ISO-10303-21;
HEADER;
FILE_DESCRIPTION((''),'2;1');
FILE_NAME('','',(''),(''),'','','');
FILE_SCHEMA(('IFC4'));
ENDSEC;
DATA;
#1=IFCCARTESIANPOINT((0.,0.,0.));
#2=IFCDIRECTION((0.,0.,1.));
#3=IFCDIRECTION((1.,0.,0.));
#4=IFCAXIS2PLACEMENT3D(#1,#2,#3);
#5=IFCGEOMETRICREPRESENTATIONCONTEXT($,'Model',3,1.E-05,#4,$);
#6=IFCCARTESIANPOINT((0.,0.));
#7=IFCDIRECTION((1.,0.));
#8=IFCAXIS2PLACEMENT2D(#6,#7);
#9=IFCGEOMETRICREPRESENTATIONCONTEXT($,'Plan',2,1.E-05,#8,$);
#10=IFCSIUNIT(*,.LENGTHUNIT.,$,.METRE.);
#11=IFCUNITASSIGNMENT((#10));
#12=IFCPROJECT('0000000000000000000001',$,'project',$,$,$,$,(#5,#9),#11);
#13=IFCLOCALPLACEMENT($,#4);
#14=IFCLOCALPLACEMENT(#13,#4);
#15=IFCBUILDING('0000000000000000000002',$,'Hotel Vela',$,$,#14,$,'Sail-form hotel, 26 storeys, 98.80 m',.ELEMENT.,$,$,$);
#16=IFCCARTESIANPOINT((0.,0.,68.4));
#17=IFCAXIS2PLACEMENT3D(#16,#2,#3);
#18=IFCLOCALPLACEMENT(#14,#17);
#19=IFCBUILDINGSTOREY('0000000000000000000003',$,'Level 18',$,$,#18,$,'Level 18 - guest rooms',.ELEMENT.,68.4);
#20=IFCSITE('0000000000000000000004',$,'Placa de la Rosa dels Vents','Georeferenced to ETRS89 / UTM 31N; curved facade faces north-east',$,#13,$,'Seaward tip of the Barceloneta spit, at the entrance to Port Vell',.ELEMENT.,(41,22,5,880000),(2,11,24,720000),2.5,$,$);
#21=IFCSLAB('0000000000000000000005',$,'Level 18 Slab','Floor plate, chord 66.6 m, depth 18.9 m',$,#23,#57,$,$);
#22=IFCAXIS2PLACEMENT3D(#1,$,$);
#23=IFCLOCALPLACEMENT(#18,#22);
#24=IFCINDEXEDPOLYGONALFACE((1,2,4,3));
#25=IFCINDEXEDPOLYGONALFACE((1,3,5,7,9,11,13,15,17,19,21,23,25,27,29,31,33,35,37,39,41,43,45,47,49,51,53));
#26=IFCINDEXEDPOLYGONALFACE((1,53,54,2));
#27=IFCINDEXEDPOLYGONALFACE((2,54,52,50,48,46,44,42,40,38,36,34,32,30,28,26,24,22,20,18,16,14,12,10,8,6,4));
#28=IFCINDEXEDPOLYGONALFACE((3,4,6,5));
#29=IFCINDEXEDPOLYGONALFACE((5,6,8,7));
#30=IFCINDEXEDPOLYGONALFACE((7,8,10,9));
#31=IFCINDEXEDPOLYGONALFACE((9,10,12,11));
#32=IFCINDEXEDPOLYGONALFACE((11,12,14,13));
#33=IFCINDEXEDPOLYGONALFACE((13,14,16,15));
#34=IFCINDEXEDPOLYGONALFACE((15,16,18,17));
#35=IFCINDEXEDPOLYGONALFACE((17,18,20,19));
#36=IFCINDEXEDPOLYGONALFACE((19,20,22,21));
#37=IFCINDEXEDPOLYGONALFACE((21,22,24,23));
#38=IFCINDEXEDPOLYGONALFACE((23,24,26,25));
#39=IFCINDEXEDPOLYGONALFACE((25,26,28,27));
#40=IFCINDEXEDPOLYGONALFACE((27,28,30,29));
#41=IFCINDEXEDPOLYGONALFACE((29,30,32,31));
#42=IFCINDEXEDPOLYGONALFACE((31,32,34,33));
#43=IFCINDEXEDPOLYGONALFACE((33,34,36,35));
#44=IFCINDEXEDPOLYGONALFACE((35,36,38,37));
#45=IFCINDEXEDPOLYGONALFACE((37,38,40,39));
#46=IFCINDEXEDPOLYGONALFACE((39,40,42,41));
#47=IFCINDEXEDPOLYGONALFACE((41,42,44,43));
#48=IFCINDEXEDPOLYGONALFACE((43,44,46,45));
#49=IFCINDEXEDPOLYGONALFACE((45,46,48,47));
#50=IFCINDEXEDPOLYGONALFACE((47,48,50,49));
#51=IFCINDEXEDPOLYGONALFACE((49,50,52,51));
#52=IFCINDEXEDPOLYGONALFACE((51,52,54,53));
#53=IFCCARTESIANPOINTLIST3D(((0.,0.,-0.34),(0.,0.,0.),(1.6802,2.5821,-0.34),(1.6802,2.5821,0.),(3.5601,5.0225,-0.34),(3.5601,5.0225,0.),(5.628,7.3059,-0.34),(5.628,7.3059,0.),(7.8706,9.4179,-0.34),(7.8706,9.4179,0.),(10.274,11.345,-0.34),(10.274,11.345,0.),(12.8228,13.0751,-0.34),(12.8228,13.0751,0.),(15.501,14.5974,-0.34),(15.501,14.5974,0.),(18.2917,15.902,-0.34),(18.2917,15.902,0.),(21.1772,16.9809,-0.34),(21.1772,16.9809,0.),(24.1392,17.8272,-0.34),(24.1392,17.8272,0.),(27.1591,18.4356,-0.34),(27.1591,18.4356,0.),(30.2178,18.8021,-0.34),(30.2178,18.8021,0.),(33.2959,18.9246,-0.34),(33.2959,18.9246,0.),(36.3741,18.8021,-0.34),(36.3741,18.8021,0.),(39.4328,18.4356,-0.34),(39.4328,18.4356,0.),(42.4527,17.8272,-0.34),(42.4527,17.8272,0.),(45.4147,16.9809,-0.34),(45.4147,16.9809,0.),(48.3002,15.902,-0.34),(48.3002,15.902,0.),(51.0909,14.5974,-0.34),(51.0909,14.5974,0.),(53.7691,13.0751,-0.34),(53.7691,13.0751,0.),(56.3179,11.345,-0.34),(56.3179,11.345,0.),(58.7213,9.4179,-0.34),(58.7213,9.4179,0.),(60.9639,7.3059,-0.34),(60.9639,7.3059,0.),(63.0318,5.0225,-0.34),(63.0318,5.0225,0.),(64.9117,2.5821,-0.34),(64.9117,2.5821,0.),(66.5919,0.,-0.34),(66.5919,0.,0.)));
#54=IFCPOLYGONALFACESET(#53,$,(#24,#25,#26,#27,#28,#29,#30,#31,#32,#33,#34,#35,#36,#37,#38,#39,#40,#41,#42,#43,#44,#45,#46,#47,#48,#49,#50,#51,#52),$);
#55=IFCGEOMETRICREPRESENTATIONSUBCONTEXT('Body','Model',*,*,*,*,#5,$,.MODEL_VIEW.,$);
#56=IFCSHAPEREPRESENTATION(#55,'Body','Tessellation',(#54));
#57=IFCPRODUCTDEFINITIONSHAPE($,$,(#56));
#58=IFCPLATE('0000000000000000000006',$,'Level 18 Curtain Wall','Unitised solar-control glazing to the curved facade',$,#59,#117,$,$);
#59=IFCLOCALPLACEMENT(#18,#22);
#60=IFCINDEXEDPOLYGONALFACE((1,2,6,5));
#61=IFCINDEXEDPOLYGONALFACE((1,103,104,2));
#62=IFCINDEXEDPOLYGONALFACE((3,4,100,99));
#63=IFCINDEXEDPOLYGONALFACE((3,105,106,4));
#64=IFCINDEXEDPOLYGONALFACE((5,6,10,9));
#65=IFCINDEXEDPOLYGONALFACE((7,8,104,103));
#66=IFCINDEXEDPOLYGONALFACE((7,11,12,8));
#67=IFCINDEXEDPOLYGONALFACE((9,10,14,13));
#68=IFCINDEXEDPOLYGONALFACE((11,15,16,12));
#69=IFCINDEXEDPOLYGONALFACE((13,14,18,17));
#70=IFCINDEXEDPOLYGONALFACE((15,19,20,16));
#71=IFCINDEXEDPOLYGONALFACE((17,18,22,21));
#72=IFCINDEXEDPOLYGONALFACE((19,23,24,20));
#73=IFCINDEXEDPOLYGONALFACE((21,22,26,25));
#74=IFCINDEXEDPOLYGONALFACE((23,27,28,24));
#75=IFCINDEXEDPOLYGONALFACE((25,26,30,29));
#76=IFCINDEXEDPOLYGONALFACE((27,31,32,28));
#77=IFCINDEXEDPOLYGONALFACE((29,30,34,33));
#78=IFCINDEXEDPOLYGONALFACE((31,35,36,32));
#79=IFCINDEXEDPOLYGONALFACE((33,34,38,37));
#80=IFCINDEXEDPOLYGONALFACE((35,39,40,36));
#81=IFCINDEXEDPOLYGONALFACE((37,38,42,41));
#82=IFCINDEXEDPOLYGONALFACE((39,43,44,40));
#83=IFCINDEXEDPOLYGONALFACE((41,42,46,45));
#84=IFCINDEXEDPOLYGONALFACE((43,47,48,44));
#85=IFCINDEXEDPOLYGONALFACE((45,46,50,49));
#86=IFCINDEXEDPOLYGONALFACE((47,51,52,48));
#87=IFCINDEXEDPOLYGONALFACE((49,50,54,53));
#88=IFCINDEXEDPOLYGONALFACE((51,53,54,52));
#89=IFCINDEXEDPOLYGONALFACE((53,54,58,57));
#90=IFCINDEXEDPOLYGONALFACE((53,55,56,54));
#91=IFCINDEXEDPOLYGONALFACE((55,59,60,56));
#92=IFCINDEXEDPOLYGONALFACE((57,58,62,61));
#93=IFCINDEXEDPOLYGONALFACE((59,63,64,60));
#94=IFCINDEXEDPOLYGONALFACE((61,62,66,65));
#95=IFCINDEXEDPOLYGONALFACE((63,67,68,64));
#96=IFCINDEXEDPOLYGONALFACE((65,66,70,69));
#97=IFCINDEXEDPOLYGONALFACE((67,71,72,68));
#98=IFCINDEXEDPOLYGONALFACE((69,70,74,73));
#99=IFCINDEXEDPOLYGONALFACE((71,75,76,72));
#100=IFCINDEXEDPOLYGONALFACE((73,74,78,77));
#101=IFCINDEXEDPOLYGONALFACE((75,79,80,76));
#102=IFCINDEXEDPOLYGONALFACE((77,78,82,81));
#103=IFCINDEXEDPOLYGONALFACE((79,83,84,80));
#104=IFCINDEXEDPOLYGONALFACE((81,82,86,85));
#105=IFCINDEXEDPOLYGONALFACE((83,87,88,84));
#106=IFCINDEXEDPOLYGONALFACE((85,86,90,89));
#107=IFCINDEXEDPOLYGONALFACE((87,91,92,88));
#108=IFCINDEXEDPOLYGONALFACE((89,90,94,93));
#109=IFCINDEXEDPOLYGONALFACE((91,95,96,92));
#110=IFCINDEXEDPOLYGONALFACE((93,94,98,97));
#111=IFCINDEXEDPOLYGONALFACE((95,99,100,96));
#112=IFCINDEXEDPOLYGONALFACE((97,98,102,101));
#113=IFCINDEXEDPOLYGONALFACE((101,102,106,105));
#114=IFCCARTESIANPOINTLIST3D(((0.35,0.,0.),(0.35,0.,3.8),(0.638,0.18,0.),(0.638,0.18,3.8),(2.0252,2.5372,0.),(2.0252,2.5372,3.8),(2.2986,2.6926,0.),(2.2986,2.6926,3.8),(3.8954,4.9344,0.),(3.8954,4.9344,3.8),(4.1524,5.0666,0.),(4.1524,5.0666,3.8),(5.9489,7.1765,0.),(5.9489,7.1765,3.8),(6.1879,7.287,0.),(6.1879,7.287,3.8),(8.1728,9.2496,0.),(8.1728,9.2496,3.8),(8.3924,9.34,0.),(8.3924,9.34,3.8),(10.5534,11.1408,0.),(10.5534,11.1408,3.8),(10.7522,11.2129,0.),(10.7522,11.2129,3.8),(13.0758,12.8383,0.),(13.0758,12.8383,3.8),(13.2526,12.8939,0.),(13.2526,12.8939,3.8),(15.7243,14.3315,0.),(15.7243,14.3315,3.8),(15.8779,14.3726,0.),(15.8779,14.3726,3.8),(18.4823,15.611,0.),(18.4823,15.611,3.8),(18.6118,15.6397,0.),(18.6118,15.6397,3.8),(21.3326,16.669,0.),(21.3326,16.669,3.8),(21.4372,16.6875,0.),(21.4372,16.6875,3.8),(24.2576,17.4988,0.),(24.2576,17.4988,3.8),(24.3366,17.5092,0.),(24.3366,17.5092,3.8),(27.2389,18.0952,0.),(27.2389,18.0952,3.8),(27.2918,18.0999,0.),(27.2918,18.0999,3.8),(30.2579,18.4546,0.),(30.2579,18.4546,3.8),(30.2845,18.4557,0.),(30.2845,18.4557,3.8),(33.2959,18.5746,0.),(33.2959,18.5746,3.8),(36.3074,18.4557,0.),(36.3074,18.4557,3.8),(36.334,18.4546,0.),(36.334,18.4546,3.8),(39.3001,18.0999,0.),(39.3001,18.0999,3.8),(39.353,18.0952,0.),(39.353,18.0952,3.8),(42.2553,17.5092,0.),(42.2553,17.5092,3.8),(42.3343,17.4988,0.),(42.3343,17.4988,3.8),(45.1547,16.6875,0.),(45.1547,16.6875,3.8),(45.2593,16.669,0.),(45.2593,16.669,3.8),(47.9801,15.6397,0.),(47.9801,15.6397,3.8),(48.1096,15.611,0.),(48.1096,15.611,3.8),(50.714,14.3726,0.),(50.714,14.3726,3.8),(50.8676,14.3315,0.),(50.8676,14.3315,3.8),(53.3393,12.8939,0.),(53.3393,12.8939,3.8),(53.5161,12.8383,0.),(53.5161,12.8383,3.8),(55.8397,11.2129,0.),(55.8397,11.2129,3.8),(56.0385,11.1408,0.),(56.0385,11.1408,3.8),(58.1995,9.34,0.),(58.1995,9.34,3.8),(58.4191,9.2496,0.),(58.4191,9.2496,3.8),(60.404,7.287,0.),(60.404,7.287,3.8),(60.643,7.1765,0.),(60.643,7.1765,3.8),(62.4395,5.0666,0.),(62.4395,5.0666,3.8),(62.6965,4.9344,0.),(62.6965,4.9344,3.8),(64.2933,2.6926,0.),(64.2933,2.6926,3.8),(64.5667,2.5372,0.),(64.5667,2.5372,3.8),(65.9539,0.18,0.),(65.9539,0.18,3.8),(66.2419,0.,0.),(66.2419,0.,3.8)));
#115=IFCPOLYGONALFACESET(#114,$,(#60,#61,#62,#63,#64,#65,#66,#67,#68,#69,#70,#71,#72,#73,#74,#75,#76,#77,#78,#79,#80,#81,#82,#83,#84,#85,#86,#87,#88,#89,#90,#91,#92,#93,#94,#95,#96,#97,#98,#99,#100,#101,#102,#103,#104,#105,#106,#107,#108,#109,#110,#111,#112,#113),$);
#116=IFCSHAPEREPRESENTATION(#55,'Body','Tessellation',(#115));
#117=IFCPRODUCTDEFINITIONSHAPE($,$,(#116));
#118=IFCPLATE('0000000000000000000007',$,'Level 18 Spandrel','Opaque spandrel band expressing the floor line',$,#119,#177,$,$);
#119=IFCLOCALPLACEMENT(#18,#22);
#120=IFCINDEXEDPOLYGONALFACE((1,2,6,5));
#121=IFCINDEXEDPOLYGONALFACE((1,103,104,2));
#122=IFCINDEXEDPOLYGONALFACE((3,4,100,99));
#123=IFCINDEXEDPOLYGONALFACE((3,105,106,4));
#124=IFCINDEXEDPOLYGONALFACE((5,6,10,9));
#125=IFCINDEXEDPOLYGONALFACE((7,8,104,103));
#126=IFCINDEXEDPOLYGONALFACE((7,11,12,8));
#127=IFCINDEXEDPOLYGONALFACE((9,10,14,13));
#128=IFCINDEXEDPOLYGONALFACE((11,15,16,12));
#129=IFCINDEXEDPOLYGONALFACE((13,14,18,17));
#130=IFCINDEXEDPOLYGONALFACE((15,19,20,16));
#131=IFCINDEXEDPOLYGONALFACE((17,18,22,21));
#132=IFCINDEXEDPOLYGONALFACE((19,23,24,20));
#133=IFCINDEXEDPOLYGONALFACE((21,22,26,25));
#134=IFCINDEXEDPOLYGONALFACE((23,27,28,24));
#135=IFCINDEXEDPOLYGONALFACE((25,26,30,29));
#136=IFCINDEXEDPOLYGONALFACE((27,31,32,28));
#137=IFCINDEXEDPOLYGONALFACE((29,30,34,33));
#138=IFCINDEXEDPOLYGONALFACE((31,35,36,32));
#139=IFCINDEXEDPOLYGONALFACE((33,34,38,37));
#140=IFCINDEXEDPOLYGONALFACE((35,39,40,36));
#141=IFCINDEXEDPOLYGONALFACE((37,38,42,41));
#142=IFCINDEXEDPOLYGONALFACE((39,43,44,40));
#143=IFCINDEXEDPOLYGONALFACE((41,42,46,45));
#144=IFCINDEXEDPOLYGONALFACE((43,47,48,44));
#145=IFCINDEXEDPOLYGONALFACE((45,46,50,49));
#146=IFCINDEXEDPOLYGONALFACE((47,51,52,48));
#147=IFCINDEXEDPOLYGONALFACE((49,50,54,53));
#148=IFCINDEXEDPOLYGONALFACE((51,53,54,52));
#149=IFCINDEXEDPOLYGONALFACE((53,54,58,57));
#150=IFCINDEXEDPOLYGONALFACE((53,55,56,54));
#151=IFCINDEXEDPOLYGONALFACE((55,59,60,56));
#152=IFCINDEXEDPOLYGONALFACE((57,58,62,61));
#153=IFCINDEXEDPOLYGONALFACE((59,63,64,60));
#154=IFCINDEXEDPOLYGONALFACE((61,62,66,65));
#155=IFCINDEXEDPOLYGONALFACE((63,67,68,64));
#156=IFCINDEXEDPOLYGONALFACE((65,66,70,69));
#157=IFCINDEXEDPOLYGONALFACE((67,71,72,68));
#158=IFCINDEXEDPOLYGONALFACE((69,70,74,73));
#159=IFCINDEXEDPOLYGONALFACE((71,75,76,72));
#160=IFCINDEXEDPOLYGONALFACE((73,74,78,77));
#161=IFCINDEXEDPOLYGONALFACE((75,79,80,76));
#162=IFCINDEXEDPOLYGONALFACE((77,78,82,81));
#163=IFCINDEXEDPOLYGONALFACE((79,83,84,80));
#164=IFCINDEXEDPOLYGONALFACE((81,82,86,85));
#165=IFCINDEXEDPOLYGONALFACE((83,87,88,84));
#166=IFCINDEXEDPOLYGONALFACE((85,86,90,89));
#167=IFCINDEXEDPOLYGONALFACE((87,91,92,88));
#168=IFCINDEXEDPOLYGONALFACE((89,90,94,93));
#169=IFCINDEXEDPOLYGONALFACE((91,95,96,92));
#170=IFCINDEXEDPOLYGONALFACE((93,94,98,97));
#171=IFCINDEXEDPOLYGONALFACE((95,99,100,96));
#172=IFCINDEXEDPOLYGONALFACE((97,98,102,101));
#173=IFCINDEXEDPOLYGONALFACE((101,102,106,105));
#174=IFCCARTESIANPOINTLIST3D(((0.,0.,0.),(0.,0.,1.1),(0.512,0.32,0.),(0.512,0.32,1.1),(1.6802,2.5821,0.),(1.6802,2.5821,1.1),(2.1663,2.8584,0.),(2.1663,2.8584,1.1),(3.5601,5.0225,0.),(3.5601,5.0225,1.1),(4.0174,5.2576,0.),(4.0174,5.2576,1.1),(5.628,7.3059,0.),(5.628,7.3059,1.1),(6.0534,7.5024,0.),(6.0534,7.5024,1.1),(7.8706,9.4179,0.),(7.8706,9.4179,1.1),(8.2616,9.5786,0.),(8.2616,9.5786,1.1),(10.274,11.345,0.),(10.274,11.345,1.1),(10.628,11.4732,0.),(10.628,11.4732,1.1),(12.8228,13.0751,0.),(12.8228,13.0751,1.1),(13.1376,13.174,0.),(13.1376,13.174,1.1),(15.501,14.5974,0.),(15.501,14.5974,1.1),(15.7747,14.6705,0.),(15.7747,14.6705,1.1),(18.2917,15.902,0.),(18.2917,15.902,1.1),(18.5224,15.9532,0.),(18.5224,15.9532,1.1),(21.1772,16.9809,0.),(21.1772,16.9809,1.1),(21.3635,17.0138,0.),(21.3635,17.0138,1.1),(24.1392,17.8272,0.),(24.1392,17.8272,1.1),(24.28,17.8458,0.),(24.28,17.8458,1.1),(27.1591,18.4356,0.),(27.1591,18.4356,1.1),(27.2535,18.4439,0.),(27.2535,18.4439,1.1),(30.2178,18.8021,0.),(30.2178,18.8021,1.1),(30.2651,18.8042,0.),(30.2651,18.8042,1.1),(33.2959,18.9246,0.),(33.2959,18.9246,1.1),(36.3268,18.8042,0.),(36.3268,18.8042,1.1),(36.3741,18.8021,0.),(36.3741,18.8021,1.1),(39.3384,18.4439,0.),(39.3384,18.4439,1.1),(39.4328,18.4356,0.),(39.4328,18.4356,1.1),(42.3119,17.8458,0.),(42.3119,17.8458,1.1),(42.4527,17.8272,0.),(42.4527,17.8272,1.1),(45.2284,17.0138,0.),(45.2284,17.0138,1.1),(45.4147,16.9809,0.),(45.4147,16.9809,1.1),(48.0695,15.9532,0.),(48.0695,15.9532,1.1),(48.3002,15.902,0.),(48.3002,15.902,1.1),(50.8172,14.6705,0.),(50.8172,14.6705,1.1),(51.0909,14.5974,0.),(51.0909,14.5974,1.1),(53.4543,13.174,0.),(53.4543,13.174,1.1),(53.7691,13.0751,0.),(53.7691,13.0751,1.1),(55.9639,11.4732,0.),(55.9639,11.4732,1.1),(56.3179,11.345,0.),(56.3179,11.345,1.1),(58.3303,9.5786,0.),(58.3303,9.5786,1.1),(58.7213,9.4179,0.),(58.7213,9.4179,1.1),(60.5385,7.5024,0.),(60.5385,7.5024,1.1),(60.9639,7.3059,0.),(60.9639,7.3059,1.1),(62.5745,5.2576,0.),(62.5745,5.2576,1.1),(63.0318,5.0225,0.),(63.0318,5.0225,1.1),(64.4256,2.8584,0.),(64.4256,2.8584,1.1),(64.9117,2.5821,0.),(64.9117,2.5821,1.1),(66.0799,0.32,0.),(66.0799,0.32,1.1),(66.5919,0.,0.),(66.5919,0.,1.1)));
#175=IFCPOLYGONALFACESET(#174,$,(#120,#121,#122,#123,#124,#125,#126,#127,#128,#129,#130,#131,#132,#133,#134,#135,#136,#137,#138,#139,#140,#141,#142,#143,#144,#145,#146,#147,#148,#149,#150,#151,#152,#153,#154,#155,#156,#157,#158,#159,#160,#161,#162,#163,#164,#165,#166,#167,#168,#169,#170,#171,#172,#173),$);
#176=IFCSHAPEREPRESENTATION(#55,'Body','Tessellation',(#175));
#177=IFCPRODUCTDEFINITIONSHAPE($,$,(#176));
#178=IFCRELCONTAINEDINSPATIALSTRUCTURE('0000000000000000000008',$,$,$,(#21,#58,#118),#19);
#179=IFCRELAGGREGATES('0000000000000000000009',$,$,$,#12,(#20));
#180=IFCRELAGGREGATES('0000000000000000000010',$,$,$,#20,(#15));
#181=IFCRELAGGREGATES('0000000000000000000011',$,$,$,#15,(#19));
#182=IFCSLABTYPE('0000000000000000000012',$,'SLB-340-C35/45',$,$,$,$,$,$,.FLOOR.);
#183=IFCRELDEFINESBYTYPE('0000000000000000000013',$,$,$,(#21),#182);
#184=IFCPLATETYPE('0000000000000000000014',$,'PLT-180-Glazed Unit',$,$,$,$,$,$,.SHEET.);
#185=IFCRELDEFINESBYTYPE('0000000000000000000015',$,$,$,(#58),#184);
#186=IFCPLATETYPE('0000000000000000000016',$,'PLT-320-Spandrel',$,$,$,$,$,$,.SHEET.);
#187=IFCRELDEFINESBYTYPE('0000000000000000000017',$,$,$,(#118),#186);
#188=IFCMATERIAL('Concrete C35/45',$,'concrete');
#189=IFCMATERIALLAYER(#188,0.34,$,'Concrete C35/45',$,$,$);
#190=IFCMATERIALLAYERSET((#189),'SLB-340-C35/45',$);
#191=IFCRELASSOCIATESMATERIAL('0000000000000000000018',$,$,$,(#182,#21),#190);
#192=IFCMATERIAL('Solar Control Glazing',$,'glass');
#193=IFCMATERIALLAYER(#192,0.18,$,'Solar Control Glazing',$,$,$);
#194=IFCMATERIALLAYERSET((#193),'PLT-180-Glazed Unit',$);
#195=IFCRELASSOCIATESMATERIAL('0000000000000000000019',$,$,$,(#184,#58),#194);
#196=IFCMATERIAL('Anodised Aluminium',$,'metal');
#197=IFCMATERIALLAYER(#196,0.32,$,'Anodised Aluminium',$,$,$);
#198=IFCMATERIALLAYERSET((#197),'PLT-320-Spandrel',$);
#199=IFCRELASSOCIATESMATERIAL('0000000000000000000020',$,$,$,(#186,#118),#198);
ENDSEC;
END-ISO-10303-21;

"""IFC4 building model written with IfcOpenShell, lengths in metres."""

from ifc_helpers import new_model, si_unit, frame, origin_with_axes, origin_2d_with_axis, place, context, subcontext, project, spatial, line, indexed_curve, outline, extrude, material, layer, layer_set, layer_usage, type_object, element, save


model = new_model("IFC4")

# Units and contexts
model_context = context("Model", 3, precision=1e-05, world=origin_with_axes())
plan_context = context("Plan", 2, precision=1e-05, world=origin_2d_with_axis())
body_context = subcontext(model_context, "Body", "Model", "MODEL_VIEW")
ifc_project = project(units=[si_unit("LENGTHUNIT", "METRE")], contexts=[model_context, plan_context])

# Site, building, storey
site_placement = place(None, origin_with_axes())
site = spatial("IfcSite", under=ifc_project, at=site_placement, Name="Placa de la Rosa dels Vents", Description="Georeferenced to ETRS89 / UTM 31N; curved facade faces north-east", LongName="Seaward tip of the Barceloneta spit, at the entrance to Port Vell", CompositionType="ELEMENT", RefLatitude=(41, 22, 5, 880000), RefLongitude=(2, 11, 24, 720000), RefElevation=2.5)
building_placement = place(site_placement, origin_with_axes())
building = spatial("IfcBuilding", under=site, at=building_placement, Name="Hotel Vela", LongName="Sail-form hotel, 26 storeys, 98.80 m", CompositionType="ELEMENT")
storey_placement = place(building_placement, frame((0.0, 0.0, 68.4), z_axis=(0.0, 0.0, 1.0), x_axis=(1.0, 0.0, 0.0)))
storey = spatial("IfcBuildingStorey", under=building, at=storey_placement, Name="Level 18", LongName="Level 18 - guest rooms", CompositionType="ELEMENT", Elevation=68.4)

# Slab
ifc_material_1 = material(Name="Concrete C35/45", Category="concrete")
ifc_layer_1 = layer(ifc_material_1, 0.34, Name="Concrete C35/45")
ifc_layer_set_1 = layer_set([ifc_layer_1], Name="SLB-340-C35/45")
ifc_layer_usage_1 = layer_usage(ifc_layer_set_1, "AXIS3", "POSITIVE", 0.0)
slab_type = type_object("IfcSlabType", Name="SLB-340-C35/45", PredefinedType="FLOOR", material=ifc_layer_set_1)
slab_placement = place(storey_placement, frame((0.0, 0.0, -0.34), z_axis=(0.0, 0.0, 1.0), x_axis=(1.0, 0.0, 0.0)))
element("IfcSlab", 1, at=slab_placement, inside=storey, type_object=slab_type, material=ifc_layer_usage_1, Name="Level 18 Slab", Description="Floor plate, chord 66.6 m, depth 18.9 m", context=body_context, shape_type="SweptSolid", body=[
    extrude(outline(indexed_curve([(0.0, 0.0), (66.5919, 0.0), (64.9117, 2.5821), (63.0318, 5.0225), (60.9639, 7.3059), (58.7213, 9.4179), (56.3179, 11.345), (53.7691, 13.0751), (51.0909, 14.5974), (48.3002, 15.902), (45.4147, 16.9809), (42.4527, 17.8272), (39.4328, 18.4356), (36.3741, 18.8021), (33.2959, 18.9246), (30.2178, 18.8021), (27.1591, 18.4356), (24.1392, 17.8272), (21.1772, 16.9809), (18.2917, 15.902), (15.501, 14.5974), (12.8228, 13.0751), (10.274, 11.345), (7.8706, 9.4179), (5.628, 7.3059), (3.5601, 5.0225), (1.6802, 2.5821)], segments=[line(1, 2, 3, 4, 5, 6, 7, 8, 9, 10, 11, 12, 13, 14, 15, 16, 17, 18, 19, 20, 21, 22, 23, 24, 25, 26, 27, 1)])), origin_with_axes(), (0.0, 0.0, 1.0), 0.34),
])

# Plates
ifc_material_2 = material(Name="Solar Control Glazing", Category="glass")
ifc_layer_2 = layer(ifc_material_2, 0.18, Name="Solar Control Glazing")
ifc_layer_set_2 = layer_set([ifc_layer_2], Name="PLT-180-Glazed Unit")
ifc_layer_usage_2 = layer_usage(ifc_layer_set_2, "AXIS2", "POSITIVE", 0.0)
plate_type_1 = type_object("IfcPlateType", Name="PLT-180-Glazed Unit", PredefinedType="SHEET", material=ifc_layer_set_2)
plate_1_placement = place(storey_placement, frame((0.35, 0.0, 0.0), z_axis=(0.0, 0.0, 1.0), x_axis=(1.0, 0.0, 0.0)))
element("IfcPlate", 2, at=plate_1_placement, inside=storey, type_object=plate_type_1, material=ifc_layer_usage_2, Name="Level 18 Curtain Wall", Description="Unitised solar-control glazing to the curved facade", context=body_context, shape_type="SweptSolid", body=[
    extrude(outline(indexed_curve([(65.8919, 0.0), (64.2167, 2.5372), (62.3465, 4.9344), (60.293, 7.1765), (58.0691, 9.2496), (55.6885, 11.1408), (53.1661, 12.8383), (50.5176, 14.3315), (47.7596, 15.611), (44.9093, 16.669), (41.9843, 17.4988), (39.003, 18.0952), (35.984, 18.4546), (32.9459, 18.5746), (29.9079, 18.4546), (26.8889, 18.0952), (23.9076, 17.4988), (20.9826, 16.669), (18.1323, 15.611), (15.3743, 14.3315), (12.7258, 12.8383), (10.2034, 11.1408), (7.8228, 9.2496), (5.5989, 7.1765), (3.5454, 4.9344), (1.6752, 2.5372), (0.0, 0.0), (65.6039, 0.18), (1.9486, 2.6926), (3.8024, 5.0666), (5.8379, 7.287), (8.0424, 9.34), (10.4022, 11.2129), (12.9026, 12.8939), (15.5279, 14.3726), (18.2618, 15.6397), (21.0872, 16.6875), (23.9866, 17.5092), (26.9418, 18.0999), (29.9345, 18.4557), (32.9459, 18.5746), (35.9574, 18.4557), (38.9501, 18.0999), (41.9053, 17.5092), (44.8047, 16.6875), (47.6301, 15.6397), (50.364, 14.3726), (52.9893, 12.8939), (55.4897, 11.2129), (57.8495, 9.34), (60.054, 7.287), (62.0895, 5.0666), (63.9433, 2.6926), (0.288, 0.18)], segments=[line(1, 2, 3, 4, 5, 6, 7, 8, 9, 10, 11, 12, 13, 14, 15, 16, 17, 18, 19, 20, 21, 22, 23, 24, 25, 26, 27, 28, 29, 30, 31, 32, 33, 34, 35, 36, 37, 38, 39, 40, 41, 42, 43, 44, 45, 46, 47, 48, 49, 50, 51, 52, 53, 54, 1)])), origin_with_axes(), (0.0, 0.0, 1.0), 3.8),
])
ifc_material_3 = material(Name="Anodised Aluminium", Category="metal")
ifc_layer_3 = layer(ifc_material_3, 0.32, Name="Anodised Aluminium")
ifc_layer_set_3 = layer_set([ifc_layer_3], Name="PLT-320-Spandrel")
ifc_layer_usage_3 = layer_usage(ifc_layer_set_3, "AXIS2", "POSITIVE", 0.0)
plate_type_2 = type_object("IfcPlateType", Name="PLT-320-Spandrel", PredefinedType="SHEET", material=ifc_layer_set_3)
plate_2_placement = place(storey_placement, origin_with_axes())
element("IfcPlate", 3, at=plate_2_placement, inside=storey, type_object=plate_type_2, material=ifc_layer_usage_3, Name="Level 18 Spandrel", Description="Opaque spandrel band expressing the floor line", context=body_context, shape_type="SweptSolid", body=[
    extrude(outline(indexed_curve([(66.5919, 0.0), (64.9117, 2.5821), (63.0318, 5.0225), (60.9639, 7.3059), (58.7213, 9.4179), (56.3179, 11.345), (53.7691, 13.0751), (51.0909, 14.5974), (48.3002, 15.902), (45.4147, 16.9809), (42.4527, 17.8272), (39.4328, 18.4356), (36.3741, 18.8021), (33.2959, 18.9246), (30.2178, 18.8021), (27.1591, 18.4356), (24.1392, 17.8272), (21.1772, 16.9809), (18.2917, 15.902), (15.501, 14.5974), (12.8228, 13.0751), (10.274, 11.345), (7.8706, 9.4179), (5.628, 7.3059), (3.5601, 5.0225), (1.6802, 2.5821), (0.0, 0.0), (66.0799, 0.32), (2.1663, 2.8584), (4.0174, 5.2576), (6.0534, 7.5024), (8.2616, 9.5786), (10.628, 11.4732), (13.1376, 13.174), (15.7747, 14.6705), (18.5224, 15.9532), (21.3635, 17.0138), (24.28, 17.8458), (27.2535, 18.4439), (30.2651, 18.8042), (33.2959, 18.9246), (36.3268, 18.8042), (39.3384, 18.4439), (42.3119, 17.8458), (45.2284, 17.0138), (48.0695, 15.9532), (50.8172, 14.6705), (53.4543, 13.174), (55.9639, 11.4732), (58.3303, 9.5786), (60.5385, 7.5024), (62.5745, 5.2576), (64.4256, 2.8584), (0.512, 0.32)], segments=[line(1, 2, 3, 4, 5, 6, 7, 8, 9, 10, 11, 12, 13, 14, 15, 16, 17, 18, 19, 20, 21, 22, 23, 24, 25, 26, 27, 28, 29, 30, 31, 32, 33, 34, 35, 36, 37, 38, 39, 40, 41, 42, 43, 44, 45, 46, 47, 48, 49, 50, 51, 52, 53, 54, 1)])), origin_with_axes(), (0.0, 0.0, 1.0), 1.1),
])

save(model, "model.ifc")
